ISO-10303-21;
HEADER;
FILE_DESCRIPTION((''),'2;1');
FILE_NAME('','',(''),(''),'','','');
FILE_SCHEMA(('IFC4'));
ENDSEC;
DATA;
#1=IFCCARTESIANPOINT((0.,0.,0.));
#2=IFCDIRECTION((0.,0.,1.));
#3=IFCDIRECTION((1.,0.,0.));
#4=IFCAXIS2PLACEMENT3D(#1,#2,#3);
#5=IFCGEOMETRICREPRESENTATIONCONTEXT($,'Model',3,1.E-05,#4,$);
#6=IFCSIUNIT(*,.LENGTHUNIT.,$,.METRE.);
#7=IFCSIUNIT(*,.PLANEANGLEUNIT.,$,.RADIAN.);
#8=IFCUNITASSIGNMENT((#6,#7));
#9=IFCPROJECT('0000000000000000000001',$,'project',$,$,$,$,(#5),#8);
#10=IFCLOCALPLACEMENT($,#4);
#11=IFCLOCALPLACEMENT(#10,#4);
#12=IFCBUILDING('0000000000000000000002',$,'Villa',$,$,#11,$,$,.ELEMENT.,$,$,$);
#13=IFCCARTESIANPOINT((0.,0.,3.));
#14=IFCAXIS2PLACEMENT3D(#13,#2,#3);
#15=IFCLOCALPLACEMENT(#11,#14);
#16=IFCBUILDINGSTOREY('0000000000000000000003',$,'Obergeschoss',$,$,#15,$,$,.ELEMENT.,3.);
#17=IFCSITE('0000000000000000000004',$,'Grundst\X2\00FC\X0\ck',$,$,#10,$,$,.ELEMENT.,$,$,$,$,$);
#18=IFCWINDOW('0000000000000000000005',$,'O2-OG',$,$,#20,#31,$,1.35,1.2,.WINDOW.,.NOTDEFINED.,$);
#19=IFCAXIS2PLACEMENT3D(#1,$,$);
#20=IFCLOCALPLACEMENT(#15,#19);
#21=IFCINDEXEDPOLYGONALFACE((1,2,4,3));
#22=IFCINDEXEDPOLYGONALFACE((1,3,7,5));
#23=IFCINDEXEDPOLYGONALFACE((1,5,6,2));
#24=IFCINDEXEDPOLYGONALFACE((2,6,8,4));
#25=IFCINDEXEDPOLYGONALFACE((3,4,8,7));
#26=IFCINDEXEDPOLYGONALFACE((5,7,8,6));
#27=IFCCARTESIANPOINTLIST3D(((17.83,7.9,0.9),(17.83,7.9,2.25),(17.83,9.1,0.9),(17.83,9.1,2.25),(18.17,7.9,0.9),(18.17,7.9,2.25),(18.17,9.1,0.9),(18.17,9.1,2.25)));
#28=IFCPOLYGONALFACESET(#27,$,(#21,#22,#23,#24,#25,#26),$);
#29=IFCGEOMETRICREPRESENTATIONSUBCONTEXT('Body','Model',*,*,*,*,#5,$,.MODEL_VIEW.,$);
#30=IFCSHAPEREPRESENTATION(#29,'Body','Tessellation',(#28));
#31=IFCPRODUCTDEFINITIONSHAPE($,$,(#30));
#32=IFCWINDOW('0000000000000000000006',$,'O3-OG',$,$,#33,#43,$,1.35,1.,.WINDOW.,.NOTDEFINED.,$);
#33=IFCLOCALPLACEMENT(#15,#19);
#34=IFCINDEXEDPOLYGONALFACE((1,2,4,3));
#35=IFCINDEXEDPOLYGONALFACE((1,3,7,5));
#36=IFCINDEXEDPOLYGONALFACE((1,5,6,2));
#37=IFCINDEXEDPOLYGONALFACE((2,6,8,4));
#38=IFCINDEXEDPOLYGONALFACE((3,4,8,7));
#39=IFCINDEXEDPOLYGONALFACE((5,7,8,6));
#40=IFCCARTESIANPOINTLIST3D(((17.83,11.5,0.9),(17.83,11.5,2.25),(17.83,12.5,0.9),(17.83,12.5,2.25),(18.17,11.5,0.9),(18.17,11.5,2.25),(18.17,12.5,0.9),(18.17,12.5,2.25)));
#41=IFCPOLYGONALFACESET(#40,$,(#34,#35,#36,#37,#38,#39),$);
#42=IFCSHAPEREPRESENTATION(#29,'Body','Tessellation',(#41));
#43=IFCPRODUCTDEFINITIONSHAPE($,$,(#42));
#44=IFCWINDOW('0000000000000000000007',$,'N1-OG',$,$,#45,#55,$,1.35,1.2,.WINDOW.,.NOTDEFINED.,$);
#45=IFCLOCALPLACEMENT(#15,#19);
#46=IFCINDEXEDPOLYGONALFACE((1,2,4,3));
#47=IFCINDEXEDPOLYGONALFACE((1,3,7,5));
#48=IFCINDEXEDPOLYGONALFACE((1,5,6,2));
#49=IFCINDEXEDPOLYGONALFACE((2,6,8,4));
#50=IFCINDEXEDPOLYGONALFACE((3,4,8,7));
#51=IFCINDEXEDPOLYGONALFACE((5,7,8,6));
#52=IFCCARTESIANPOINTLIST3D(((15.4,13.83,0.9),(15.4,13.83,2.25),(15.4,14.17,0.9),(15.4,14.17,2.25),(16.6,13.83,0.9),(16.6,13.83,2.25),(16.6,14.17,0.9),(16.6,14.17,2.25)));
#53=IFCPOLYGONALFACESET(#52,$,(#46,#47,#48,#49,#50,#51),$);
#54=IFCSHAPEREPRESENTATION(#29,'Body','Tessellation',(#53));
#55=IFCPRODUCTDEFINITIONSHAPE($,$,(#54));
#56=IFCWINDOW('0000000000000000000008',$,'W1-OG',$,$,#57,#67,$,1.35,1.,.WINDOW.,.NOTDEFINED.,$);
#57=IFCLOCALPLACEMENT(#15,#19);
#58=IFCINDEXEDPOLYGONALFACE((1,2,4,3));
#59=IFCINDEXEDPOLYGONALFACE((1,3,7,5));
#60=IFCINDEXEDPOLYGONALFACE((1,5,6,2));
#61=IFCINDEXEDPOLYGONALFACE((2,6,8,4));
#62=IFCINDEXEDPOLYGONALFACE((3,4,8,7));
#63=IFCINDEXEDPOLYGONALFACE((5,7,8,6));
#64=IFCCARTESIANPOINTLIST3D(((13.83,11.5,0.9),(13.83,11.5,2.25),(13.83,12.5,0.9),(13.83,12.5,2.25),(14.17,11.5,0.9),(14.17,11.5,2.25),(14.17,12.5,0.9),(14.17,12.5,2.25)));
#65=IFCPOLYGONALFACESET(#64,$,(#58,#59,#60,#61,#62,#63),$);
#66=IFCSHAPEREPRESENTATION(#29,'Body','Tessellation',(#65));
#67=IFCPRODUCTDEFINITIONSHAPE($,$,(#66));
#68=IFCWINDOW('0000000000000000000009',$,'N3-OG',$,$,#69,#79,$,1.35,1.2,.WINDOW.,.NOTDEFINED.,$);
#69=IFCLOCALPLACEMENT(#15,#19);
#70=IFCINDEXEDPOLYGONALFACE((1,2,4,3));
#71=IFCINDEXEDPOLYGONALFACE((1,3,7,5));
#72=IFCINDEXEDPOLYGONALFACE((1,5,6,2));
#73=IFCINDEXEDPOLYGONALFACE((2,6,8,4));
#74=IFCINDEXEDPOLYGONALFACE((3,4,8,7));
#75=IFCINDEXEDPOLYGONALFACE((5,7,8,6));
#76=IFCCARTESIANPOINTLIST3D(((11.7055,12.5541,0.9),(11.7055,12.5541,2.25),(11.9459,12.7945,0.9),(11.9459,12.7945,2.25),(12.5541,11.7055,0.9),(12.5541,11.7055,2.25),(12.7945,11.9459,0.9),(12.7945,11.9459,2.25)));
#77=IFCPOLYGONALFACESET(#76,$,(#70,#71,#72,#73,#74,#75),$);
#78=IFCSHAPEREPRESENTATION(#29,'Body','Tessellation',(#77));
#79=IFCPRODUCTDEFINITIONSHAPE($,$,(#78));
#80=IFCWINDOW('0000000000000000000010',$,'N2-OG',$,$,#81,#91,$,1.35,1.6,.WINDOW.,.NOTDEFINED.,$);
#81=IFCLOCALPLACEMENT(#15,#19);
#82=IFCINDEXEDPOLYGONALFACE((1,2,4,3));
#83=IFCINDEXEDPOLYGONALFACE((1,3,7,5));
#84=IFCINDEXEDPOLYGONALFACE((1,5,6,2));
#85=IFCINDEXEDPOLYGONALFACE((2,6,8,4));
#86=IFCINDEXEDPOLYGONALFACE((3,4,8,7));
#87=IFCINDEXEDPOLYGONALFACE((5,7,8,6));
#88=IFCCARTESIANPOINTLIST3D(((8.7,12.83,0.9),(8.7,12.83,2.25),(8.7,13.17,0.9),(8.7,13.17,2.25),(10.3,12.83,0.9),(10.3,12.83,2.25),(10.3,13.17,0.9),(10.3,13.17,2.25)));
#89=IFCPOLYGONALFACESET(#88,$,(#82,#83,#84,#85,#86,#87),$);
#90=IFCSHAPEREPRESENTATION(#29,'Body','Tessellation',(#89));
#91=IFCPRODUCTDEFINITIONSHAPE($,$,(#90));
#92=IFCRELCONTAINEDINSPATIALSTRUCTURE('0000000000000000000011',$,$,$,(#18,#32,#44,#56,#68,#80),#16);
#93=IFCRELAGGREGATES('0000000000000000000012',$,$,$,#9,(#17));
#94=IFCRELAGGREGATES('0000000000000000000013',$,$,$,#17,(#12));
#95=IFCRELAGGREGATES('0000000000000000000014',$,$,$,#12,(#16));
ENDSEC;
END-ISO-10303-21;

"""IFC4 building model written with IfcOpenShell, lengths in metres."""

from ifc_helpers import new_model, si_unit, frame, origin_with_axes, origin_2d, place, context, subcontext, project, spatial, rectangle, extrude, element, save


model = new_model("IFC4")

# Units and contexts
model_context = context("Model", 3, precision=1e-05, world=origin_with_axes())
body_context = subcontext(model_context, "Body", "Model", "MODEL_VIEW")
ifc_project = project(units=[si_unit("LENGTHUNIT", "METRE"), si_unit("PLANEANGLEUNIT", "RADIAN")], contexts=[model_context])

# Site, building, storey
site_placement = place(None, origin_with_axes())
site = spatial("IfcSite", under=ifc_project, at=site_placement, Name="Grundstück", CompositionType="ELEMENT")
building_placement = place(site_placement, origin_with_axes())
building = spatial("IfcBuilding", under=site, at=building_placement, Name="Villa", CompositionType="ELEMENT")
storey_placement = place(building_placement, frame((0.0, 0.0, 3.0), z_axis=(0.0, 0.0, 1.0), x_axis=(1.0, 0.0, 0.0)))
storey = spatial("IfcBuildingStorey", under=building, at=storey_placement, Name="Obergeschoss", CompositionType="ELEMENT", Elevation=3.0)

# Windows
window_1_placement = place(storey_placement, frame((18.0, 8.5, 0.9), z_axis=(0.0, 0.0, 1.0), x_axis=(0.0, 1.0, 0.0)))
element("IfcWindow", 1, at=window_1_placement, inside=storey, Name="O2-OG", OverallHeight=1.35, OverallWidth=1.2, PartitioningType="NOTDEFINED", PredefinedType="WINDOW", context=body_context, shape_type="SweptSolid", body=[
    extrude(rectangle(XDim=1.2, YDim=0.34, at=origin_2d()), origin_with_axes(), (0.0, 0.0, 1.0), 1.35),
])
window_2_placement = place(storey_placement, frame((18.0, 12.0, 0.9), z_axis=(0.0, 0.0, 1.0), x_axis=(0.0, 1.0, 0.0)))
element("IfcWindow", 2, at=window_2_placement, inside=storey, Name="O3-OG", OverallHeight=1.35, OverallWidth=1.0, PartitioningType="NOTDEFINED", PredefinedType="WINDOW", context=body_context, shape_type="SweptSolid", body=[
    extrude(rectangle(XDim=1.0, YDim=0.34, at=origin_2d()), origin_with_axes(), (0.0, 0.0, 1.0), 1.35),
])
window_3_placement = place(storey_placement, frame((16.0, 14.0, 0.9), z_axis=(0.0, 0.0, 1.0), x_axis=(1.0, 0.0, 0.0)))
element("IfcWindow", 3, at=window_3_placement, inside=storey, Name="N1-OG", OverallHeight=1.35, OverallWidth=1.2, PartitioningType="NOTDEFINED", PredefinedType="WINDOW", context=body_context, shape_type="SweptSolid", body=[
    extrude(rectangle(XDim=1.2, YDim=0.34, at=origin_2d()), origin_with_axes(), (0.0, 0.0, 1.0), 1.35),
])
window_4_placement = place(storey_placement, frame((14.0, 12.0, 0.9), z_axis=(0.0, 0.0, 1.0), x_axis=(0.0, 1.0, 0.0)))
element("IfcWindow", 4, at=window_4_placement, inside=storey, Name="W1-OG", OverallHeight=1.35, OverallWidth=1.0, PartitioningType="NOTDEFINED", PredefinedType="WINDOW", context=body_context, shape_type="SweptSolid", body=[
    extrude(rectangle(XDim=1.0, YDim=0.34, at=origin_2d()), origin_with_axes(), (0.0, 0.0, 1.0), 1.35),
])
window_5_placement = place(storey_placement, frame((12.25, 12.25, 0.9), z_axis=(0.0, 0.0, 1.0), x_axis=(-0.7071, 0.7071, 0.0)))
element("IfcWindow", 5, at=window_5_placement, inside=storey, Name="N3-OG", OverallHeight=1.35, OverallWidth=1.2, PartitioningType="NOTDEFINED", PredefinedType="WINDOW", context=body_context, shape_type="SweptSolid", body=[
    extrude(rectangle(XDim=1.2, YDim=0.34, at=origin_2d()), origin_with_axes(), (0.0, 0.0, 1.0), 1.35),
])
window_6_placement = place(storey_placement, frame((9.5, 13.0, 0.9), z_axis=(0.0, 0.0, 1.0), x_axis=(1.0, 0.0, 0.0)))
element("IfcWindow", 6, at=window_6_placement, inside=storey, Name="N2-OG", OverallHeight=1.35, OverallWidth=1.6, PartitioningType="NOTDEFINED", PredefinedType="WINDOW", context=body_context, shape_type="SweptSolid", body=[
    extrude(rectangle(XDim=1.6, YDim=0.34, at=origin_2d()), origin_with_axes(), (0.0, 0.0, 1.0), 1.35),
])

save(model, "model.ifc")
